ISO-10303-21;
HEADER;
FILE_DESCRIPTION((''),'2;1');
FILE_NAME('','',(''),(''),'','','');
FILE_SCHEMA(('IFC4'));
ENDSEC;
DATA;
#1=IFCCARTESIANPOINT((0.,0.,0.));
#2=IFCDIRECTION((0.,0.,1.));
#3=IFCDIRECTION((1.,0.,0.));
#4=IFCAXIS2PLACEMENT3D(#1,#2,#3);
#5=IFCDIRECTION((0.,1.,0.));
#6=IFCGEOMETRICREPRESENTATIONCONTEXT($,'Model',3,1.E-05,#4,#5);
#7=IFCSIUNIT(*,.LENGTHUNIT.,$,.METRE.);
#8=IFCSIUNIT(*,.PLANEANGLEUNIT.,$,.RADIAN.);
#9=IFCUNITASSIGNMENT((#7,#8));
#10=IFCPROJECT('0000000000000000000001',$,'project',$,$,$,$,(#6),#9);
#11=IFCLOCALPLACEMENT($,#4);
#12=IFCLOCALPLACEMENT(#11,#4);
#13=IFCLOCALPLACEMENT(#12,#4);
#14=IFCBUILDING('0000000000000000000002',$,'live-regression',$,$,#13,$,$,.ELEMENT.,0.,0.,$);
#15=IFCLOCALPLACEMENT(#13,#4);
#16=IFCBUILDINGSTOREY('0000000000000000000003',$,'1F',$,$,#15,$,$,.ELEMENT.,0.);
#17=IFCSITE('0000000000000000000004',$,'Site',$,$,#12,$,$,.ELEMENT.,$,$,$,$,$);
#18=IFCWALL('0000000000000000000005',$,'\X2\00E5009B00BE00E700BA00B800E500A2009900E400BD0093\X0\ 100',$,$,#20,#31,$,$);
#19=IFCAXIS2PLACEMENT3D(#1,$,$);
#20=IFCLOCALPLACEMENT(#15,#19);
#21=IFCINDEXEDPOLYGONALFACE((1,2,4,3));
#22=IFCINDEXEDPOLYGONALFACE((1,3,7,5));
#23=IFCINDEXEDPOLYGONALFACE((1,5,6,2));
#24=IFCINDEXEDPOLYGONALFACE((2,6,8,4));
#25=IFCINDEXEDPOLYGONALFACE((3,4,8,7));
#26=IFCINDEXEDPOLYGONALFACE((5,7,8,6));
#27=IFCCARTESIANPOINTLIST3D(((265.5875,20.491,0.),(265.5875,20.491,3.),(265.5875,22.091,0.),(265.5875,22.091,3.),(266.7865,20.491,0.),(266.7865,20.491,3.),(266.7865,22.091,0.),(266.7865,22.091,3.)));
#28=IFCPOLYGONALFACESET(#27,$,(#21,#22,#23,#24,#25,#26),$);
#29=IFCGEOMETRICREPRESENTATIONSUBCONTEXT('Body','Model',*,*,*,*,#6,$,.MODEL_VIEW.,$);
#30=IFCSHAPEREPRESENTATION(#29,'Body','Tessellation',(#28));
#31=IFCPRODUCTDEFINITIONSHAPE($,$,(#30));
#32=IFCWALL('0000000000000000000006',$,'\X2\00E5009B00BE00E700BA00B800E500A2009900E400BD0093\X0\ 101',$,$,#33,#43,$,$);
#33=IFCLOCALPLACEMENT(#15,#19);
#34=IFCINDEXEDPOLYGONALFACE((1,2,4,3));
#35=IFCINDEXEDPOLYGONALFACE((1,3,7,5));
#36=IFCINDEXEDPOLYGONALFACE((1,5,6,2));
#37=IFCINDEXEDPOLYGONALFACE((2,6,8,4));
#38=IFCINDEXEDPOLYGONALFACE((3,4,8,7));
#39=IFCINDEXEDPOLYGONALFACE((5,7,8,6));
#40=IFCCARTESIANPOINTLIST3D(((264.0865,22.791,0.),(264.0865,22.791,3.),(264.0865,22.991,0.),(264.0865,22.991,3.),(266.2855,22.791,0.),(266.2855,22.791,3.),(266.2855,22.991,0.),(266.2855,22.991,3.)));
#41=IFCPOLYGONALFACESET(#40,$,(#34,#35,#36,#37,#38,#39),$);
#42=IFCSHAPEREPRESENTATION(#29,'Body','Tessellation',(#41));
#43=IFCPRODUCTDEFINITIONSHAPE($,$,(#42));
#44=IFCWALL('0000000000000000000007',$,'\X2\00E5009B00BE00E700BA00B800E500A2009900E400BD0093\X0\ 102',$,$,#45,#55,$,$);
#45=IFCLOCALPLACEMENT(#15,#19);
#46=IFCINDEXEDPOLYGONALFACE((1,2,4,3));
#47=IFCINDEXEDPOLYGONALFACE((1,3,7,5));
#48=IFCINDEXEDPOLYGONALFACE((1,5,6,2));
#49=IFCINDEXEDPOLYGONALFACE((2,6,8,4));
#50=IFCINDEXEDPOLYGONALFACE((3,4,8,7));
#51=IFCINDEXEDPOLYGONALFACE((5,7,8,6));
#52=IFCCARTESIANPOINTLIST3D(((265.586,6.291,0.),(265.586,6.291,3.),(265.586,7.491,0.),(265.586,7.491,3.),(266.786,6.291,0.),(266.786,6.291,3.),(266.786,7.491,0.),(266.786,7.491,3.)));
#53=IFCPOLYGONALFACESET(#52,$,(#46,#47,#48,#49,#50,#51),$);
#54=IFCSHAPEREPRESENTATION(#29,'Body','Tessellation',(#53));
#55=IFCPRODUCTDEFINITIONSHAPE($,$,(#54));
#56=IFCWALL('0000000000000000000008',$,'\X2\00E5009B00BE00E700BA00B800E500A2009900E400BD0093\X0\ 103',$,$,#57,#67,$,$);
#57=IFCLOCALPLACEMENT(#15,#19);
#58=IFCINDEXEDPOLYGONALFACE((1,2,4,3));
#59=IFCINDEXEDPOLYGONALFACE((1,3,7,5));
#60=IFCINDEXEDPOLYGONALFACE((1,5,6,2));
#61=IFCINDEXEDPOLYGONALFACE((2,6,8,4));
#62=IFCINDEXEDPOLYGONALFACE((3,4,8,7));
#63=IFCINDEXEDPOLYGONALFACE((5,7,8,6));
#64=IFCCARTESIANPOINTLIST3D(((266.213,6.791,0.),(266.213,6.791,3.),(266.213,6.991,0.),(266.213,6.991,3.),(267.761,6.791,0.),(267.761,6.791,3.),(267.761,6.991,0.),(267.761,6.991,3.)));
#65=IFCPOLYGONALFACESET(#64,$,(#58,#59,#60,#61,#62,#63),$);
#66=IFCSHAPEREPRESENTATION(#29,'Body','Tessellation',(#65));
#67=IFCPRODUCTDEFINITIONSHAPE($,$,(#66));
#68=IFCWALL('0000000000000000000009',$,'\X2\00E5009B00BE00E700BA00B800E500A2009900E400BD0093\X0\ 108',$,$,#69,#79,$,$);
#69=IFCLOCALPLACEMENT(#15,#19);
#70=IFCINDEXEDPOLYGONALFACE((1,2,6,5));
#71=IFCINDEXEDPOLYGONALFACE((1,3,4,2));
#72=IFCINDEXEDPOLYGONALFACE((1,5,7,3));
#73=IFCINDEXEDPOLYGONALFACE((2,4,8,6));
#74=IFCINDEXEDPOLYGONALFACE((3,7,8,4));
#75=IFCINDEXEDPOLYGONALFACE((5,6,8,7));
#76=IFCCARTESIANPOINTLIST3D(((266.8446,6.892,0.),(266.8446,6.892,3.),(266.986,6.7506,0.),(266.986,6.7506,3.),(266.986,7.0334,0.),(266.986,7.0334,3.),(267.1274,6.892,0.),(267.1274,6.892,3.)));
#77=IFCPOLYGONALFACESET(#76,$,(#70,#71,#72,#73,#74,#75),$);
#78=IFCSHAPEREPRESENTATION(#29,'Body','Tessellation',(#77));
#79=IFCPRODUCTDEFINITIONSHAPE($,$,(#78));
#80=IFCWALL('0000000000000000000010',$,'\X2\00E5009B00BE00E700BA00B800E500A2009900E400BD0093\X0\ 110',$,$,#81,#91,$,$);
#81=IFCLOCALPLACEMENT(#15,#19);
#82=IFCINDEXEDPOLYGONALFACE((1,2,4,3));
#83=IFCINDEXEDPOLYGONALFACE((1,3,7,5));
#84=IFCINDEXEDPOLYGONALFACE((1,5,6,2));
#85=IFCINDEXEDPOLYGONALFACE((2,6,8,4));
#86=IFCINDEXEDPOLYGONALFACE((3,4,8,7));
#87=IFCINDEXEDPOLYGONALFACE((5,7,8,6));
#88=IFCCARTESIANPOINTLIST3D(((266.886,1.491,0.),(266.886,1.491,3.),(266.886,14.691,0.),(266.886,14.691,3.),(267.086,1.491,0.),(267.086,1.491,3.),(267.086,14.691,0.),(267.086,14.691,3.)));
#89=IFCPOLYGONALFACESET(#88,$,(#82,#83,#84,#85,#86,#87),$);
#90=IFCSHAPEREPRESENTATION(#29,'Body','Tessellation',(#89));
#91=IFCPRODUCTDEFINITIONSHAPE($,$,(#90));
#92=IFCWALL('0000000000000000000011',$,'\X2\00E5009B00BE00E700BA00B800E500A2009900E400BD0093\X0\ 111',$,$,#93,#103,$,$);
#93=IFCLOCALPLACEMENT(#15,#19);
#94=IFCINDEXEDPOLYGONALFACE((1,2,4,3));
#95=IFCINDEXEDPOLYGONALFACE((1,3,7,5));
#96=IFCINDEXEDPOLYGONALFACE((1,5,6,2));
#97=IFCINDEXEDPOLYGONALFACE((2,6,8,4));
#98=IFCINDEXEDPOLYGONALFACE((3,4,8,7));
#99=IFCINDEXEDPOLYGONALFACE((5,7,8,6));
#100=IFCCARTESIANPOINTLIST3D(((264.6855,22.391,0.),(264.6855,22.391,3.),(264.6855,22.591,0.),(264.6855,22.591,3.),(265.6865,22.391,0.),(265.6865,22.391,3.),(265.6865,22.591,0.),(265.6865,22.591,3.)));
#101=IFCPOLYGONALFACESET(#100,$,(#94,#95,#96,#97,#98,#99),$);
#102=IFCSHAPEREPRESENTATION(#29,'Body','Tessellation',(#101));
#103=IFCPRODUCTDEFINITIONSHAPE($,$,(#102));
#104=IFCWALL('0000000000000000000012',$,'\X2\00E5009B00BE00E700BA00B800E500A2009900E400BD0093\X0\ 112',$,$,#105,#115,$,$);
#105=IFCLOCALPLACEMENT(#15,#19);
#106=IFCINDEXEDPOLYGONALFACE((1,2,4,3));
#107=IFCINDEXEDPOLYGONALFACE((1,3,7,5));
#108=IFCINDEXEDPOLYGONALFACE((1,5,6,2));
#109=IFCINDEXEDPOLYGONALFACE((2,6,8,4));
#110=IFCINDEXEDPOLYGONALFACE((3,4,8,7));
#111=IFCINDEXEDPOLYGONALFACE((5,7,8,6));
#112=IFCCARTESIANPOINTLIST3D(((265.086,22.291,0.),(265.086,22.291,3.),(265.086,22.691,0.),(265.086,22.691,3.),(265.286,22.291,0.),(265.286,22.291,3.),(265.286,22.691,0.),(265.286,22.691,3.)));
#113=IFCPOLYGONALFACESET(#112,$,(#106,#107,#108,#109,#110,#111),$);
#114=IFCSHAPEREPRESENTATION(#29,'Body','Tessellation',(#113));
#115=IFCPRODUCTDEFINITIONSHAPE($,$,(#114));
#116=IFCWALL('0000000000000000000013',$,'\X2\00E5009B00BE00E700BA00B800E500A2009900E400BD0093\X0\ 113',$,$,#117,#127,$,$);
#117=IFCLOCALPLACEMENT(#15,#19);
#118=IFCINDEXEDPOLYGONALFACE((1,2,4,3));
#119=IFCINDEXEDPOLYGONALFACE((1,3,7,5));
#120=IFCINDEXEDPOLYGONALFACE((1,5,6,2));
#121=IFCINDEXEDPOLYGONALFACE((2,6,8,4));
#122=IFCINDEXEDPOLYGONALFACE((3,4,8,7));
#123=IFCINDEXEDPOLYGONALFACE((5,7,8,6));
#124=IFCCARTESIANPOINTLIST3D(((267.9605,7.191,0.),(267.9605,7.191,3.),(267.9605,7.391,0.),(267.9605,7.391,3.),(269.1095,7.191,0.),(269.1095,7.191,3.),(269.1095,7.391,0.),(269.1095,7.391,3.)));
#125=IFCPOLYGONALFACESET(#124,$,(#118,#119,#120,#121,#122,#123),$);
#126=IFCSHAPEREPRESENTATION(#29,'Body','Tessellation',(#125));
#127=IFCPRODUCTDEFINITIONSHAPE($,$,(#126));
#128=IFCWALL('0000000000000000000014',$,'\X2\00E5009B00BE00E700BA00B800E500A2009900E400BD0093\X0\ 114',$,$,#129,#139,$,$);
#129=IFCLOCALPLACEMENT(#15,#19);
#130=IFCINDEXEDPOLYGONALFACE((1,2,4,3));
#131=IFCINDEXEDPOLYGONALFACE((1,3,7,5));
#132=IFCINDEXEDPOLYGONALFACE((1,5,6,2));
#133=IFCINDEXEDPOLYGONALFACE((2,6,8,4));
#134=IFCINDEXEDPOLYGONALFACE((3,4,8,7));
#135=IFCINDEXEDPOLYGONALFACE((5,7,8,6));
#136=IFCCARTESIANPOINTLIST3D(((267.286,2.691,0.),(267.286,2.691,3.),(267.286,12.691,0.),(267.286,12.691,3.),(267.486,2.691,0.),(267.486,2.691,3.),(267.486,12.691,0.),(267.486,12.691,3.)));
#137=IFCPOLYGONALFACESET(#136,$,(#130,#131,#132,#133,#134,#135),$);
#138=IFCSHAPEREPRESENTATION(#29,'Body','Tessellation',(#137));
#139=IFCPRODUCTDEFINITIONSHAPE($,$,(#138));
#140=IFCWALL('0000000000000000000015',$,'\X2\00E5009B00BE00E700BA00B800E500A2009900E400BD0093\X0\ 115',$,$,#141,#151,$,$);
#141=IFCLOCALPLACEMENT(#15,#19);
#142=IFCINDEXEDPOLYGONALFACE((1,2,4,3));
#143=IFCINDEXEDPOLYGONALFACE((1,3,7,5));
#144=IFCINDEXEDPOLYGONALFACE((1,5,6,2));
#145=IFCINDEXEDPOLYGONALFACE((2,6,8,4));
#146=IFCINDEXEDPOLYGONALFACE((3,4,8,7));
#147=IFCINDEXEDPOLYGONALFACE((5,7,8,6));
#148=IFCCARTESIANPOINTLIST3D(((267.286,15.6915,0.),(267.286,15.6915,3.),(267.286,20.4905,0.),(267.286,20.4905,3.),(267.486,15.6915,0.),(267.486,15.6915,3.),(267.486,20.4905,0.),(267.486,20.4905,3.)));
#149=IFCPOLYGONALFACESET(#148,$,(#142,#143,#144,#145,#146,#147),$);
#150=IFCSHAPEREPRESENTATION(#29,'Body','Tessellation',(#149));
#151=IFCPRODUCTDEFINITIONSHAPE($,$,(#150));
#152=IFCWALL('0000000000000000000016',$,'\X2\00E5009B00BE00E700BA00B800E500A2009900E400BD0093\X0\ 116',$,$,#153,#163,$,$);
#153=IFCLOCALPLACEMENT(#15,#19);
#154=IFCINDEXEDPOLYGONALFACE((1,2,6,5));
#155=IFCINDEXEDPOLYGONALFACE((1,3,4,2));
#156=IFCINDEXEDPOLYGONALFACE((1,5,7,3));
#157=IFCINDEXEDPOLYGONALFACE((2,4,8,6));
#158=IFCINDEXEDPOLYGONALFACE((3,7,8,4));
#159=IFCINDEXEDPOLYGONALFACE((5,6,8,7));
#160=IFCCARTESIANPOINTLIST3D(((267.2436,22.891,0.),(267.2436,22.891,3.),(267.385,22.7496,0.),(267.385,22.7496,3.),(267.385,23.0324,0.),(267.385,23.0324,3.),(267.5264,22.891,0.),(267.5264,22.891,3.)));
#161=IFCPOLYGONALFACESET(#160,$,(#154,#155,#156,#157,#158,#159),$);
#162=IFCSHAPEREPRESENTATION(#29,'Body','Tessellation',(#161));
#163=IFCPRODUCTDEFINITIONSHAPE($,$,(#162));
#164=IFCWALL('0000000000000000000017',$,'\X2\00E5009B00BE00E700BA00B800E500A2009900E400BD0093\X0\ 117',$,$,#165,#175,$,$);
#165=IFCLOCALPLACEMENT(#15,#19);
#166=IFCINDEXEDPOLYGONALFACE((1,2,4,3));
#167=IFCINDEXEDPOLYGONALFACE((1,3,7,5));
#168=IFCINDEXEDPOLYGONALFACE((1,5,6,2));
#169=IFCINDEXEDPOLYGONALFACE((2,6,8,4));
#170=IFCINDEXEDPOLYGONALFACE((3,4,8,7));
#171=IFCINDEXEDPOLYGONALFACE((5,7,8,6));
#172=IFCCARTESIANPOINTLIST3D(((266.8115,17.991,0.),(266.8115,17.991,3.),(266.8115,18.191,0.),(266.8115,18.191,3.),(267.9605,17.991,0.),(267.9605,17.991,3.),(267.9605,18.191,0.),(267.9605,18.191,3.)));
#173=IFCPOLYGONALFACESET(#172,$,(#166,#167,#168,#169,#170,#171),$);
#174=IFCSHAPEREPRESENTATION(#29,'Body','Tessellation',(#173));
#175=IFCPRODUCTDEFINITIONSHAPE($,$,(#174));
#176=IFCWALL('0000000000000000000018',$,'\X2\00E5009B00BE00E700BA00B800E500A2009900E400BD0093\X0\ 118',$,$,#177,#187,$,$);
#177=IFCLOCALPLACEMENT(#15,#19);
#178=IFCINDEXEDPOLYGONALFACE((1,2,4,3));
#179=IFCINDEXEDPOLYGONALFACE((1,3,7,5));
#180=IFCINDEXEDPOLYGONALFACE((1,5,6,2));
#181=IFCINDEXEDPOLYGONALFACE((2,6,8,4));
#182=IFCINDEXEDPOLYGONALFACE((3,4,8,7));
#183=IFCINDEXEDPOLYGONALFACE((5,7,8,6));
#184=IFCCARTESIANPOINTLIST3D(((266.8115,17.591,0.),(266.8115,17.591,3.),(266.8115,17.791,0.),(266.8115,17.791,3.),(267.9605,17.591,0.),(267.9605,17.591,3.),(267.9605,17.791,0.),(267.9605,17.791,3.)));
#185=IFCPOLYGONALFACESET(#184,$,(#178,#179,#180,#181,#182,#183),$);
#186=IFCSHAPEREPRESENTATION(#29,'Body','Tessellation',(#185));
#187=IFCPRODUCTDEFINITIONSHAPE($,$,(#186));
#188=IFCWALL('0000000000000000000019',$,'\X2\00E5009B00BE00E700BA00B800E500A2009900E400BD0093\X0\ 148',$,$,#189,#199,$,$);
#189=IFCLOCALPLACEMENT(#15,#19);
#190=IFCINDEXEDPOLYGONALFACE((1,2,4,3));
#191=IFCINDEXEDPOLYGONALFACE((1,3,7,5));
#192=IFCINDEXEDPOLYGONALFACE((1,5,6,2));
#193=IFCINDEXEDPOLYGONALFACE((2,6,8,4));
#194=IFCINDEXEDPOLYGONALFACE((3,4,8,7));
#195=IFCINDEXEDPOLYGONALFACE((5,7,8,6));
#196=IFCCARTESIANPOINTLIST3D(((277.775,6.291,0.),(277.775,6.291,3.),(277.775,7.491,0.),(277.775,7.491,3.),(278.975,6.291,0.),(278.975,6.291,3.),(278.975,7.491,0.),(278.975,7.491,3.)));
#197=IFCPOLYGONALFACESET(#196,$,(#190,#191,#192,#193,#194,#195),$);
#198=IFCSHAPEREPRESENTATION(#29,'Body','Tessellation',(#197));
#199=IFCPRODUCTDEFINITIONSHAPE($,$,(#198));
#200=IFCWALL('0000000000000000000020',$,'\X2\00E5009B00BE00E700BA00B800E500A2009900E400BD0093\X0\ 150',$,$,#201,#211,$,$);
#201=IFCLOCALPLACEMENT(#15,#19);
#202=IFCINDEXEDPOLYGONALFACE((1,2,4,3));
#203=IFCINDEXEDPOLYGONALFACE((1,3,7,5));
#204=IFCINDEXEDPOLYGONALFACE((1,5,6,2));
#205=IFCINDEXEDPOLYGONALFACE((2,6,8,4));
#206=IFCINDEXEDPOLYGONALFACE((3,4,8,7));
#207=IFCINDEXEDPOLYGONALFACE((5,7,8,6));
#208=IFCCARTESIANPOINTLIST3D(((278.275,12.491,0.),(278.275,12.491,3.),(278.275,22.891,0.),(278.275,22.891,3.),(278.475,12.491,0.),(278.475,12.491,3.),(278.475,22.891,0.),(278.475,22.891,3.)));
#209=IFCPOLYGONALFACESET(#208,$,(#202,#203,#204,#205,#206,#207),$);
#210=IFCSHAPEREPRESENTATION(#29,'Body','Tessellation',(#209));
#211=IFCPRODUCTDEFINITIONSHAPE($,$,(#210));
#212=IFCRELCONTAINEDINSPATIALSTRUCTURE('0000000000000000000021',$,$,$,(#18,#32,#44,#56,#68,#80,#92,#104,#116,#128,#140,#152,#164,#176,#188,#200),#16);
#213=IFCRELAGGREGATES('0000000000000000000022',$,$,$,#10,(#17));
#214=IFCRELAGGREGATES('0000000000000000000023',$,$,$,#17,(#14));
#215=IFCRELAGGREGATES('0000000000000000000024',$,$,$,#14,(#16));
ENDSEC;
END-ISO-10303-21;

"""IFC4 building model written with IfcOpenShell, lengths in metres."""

from ifc_helpers import new_model, si_unit, direction, frame, frame_2d, origin_with_axes, place, context, subcontext, project, spatial, rectangle, extrude, element, save


model = new_model("IFC4")

# Units and contexts
model_context = context("Model", 3, precision=1e-05, world=origin_with_axes(), true_north=direction((0.0, 1.0, 0.0)))
body_context = subcontext(model_context, "Body", "Model", "MODEL_VIEW")
ifc_project = project(units=[si_unit("LENGTHUNIT", "METRE"), si_unit("PLANEANGLEUNIT", "RADIAN")], contexts=[model_context])

# Site, building, storey
placement = place(None, origin_with_axes())
site_placement = place(placement, origin_with_axes())
site = spatial("IfcSite", under=ifc_project, at=site_placement, Name="Site", CompositionType="ELEMENT")
building_placement = place(site_placement, origin_with_axes())
building = spatial("IfcBuilding", under=site, at=building_placement, Name="live-regression", CompositionType="ELEMENT", ElevationOfRefHeight=0.0, ElevationOfTerrain=0.0)
storey_placement = place(building_placement, origin_with_axes())
storey = spatial("IfcBuildingStorey", under=building, at=storey_placement, Name="1F", CompositionType="ELEMENT", Elevation=0.0)

# Walls
wall_1_placement = place(storey_placement, frame((266.187, 21.291, 0.0), z_axis=(0.0, 0.0, 1.0), x_axis=(1.0, 0.0, 0.0)))
element("IfcWall", 1, at=wall_1_placement, inside=storey, Name="å\u009b¾çº¸å¢\u0099ä½\u0093 100", context=body_context, shape_type="SweptSolid", body=[
    extrude(rectangle(XDim=1.199, YDim=1.6, at=frame_2d((0.0, 0.0), x_axis=(1.0, 0.0, 0.0))), frame((0.0, 0.0, 0.0), z_axis=(0.0, 0.0, 1.0)), (0.0, 0.0, 1.0), 3.0),
])
wall_2_placement = place(storey_placement, frame((265.186, 22.891, 0.0), z_axis=(0.0, 0.0, 1.0), x_axis=(1.0, 0.0, 0.0)))
element("IfcWall", 2, at=wall_2_placement, inside=storey, Name="å\u009b¾çº¸å¢\u0099ä½\u0093 101", context=body_context, shape_type="SweptSolid", body=[
    extrude(rectangle(XDim=2.199, YDim=0.2, at=frame_2d((0.0, 0.0), x_axis=(1.0, 0.0, 0.0))), frame((0.0, 0.0, 0.0), z_axis=(0.0, 0.0, 1.0)), (0.0, 0.0, 1.0), 3.0),
])
wall_3_placement = place(storey_placement, frame((266.186, 6.891, 0.0), z_axis=(0.0, 0.0, 1.0), x_axis=(1.0, 0.0, 0.0)))
element("IfcWall", 3, at=wall_3_placement, inside=storey, Name="å\u009b¾çº¸å¢\u0099ä½\u0093 102", context=body_context, shape_type="SweptSolid", body=[
    extrude(rectangle(XDim=1.2, YDim=1.2, at=frame_2d((0.0, 0.0), x_axis=(1.0, 0.0, 0.0))), frame((0.0, 0.0, 0.0), z_axis=(0.0, 0.0, 1.0)), (0.0, 0.0, 1.0), 3.0),
])
wall_4_placement = place(storey_placement, frame((266.987, 6.891, 0.0), z_axis=(0.0, 0.0, 1.0), x_axis=(1.0, 0.0, 0.0)))
element("IfcWall", 4, at=wall_4_placement, inside=storey, Name="å\u009b¾çº¸å¢\u0099ä½\u0093 103", context=body_context, shape_type="SweptSolid", body=[
    extrude(rectangle(XDim=1.548, YDim=0.2, at=frame_2d((0.0, 0.0), x_axis=(1.0, 0.0, 0.0))), frame((0.0, 0.0, 0.0), z_axis=(0.0, 0.0, 1.0)), (0.0, 0.0, 1.0), 3.0),
])
wall_5_placement = place(storey_placement, frame((266.986, 6.892, 0.0), z_axis=(0.0, 0.0, 1.0), x_axis=(0.707107, -0.707107, 0.0)))
element("IfcWall", 5, at=wall_5_placement, inside=storey, Name="å\u009b¾çº¸å¢\u0099ä½\u0093 108", context=body_context, shape_type="SweptSolid", body=[
    extrude(rectangle(XDim=0.2, YDim=0.2, at=frame_2d((0.0, 0.0), x_axis=(1.0, 0.0, 0.0))), frame((0.0, 0.0, 0.0), z_axis=(0.0, 0.0, 1.0)), (0.0, 0.0, 1.0), 3.0),
])
wall_6_placement = place(storey_placement, frame((266.986, 8.091, 0.0), z_axis=(0.0, 0.0, 1.0), x_axis=(0.0, 1.0, 0.0)))
element("IfcWall", 6, at=wall_6_placement, inside=storey, Name="å\u009b¾çº¸å¢\u0099ä½\u0093 110", context=body_context, shape_type="SweptSolid", body=[
    extrude(rectangle(XDim=13.2, YDim=0.2, at=frame_2d((0.0, 0.0), x_axis=(1.0, 0.0, 0.0))), frame((0.0, 0.0, 0.0), z_axis=(0.0, 0.0, 1.0)), (0.0, 0.0, 1.0), 3.0),
])
wall_7_placement = place(storey_placement, frame((265.186, 22.491, 0.0), z_axis=(0.0, 0.0, 1.0), x_axis=(1.0, 0.0, 0.0)))
element("IfcWall", 7, at=wall_7_placement, inside=storey, Name="å\u009b¾çº¸å¢\u0099ä½\u0093 111", context=body_context, shape_type="SweptSolid", body=[
    extrude(rectangle(XDim=1.001, YDim=0.2, at=frame_2d((0.0, 0.0), x_axis=(1.0, 0.0, 0.0))), frame((0.0, 0.0, 0.0), z_axis=(0.0, 0.0, 1.0)), (0.0, 0.0, 1.0), 3.0),
])
wall_8_placement = place(storey_placement, frame((265.186, 22.491, 0.0), z_axis=(0.0, 0.0, 1.0), x_axis=(0.0, 1.0, 0.0)))
element("IfcWall", 8, at=wall_8_placement, inside=storey, Name="å\u009b¾çº¸å¢\u0099ä½\u0093 112", context=body_context, shape_type="SweptSolid", body=[
    extrude(rectangle(XDim=0.4, YDim=0.2, at=frame_2d((0.0, 0.0), x_axis=(1.0, 0.0, 0.0))), frame((0.0, 0.0, 0.0), z_axis=(0.0, 0.0, 1.0)), (0.0, 0.0, 1.0), 3.0),
])
wall_9_placement = place(storey_placement, frame((268.535, 7.291, 0.0), z_axis=(0.0, 0.0, 1.0), x_axis=(-1.0, 0.0, 0.0)))
element("IfcWall", 9, at=wall_9_placement, inside=storey, Name="å\u009b¾çº¸å¢\u0099ä½\u0093 113", context=body_context, shape_type="SweptSolid", body=[
    extrude(rectangle(XDim=1.149, YDim=0.2, at=frame_2d((0.0, 0.0), x_axis=(1.0, 0.0, 0.0))), frame((0.0, 0.0, 0.0), z_axis=(0.0, 0.0, 1.0)), (0.0, 0.0, 1.0), 3.0),
])
wall_10_placement = place(storey_placement, frame((267.386, 7.691, 0.0), z_axis=(0.0, 0.0, 1.0), x_axis=(0.0, 1.0, 0.0)))
element("IfcWall", 10, at=wall_10_placement, inside=storey, Name="å\u009b¾çº¸å¢\u0099ä½\u0093 114", context=body_context, shape_type="SweptSolid", body=[
    extrude(rectangle(XDim=10.0, YDim=0.2, at=frame_2d((0.0, 0.0), x_axis=(1.0, 0.0, 0.0))), frame((0.0, 0.0, 0.0), z_axis=(0.0, 0.0, 1.0)), (0.0, 0.0, 1.0), 3.0),
])
wall_11_placement = place(storey_placement, frame((267.386, 18.091, 0.0), z_axis=(0.0, 0.0, 1.0), x_axis=(0.0, 1.0, 0.0)))
element("IfcWall", 11, at=wall_11_placement, inside=storey, Name="å\u009b¾çº¸å¢\u0099ä½\u0093 115", context=body_context, shape_type="SweptSolid", body=[
    extrude(rectangle(XDim=4.799, YDim=0.2, at=frame_2d((0.0, 0.0), x_axis=(1.0, 0.0, 0.0))), frame((0.0, 0.0, 0.0), z_axis=(0.0, 0.0, 1.0)), (0.0, 0.0, 1.0), 3.0),
])
wall_12_placement = place(storey_placement, frame((267.385, 22.891, 0.0), z_axis=(0.0, 0.0, 1.0), x_axis=(0.707107, -0.707107, 0.0)))
element("IfcWall", 12, at=wall_12_placement, inside=storey, Name="å\u009b¾çº¸å¢\u0099ä½\u0093 116", context=body_context, shape_type="SweptSolid", body=[
    extrude(rectangle(XDim=0.2, YDim=0.2, at=frame_2d((0.0, 0.0), x_axis=(1.0, 0.0, 0.0))), frame((0.0, 0.0, 0.0), z_axis=(0.0, 0.0, 1.0)), (0.0, 0.0, 1.0), 3.0),
])
for number, where, z_axis, x_axis, name in (
    (13, (267.386, 18.091, 0.0), (0.0, 0.0, 1.0), (1.0, 0.0, 0.0), "å\u009b¾çº¸å¢\u0099ä½\u0093 117"),
    (14, (267.386, 17.691, 0.0), (0.0, 0.0, 1.0), (1.0, 0.0, 0.0), "å\u009b¾çº¸å¢\u0099ä½\u0093 118"),
):
    element("IfcWall", number, at=place(storey_placement, frame(where, z_axis=z_axis, x_axis=x_axis)), inside=storey, Name=name, context=body_context, shape_type="SweptSolid", body=[
        extrude(rectangle(XDim=1.149, YDim=0.2, at=frame_2d((0.0, 0.0), x_axis=(1.0, 0.0, 0.0))), frame((0.0, 0.0, 0.0), z_axis=(0.0, 0.0, 1.0)), (0.0, 0.0, 1.0), 3.0),
    ])
wall_13_placement = place(storey_placement, frame((278.375, 6.891, 0.0), z_axis=(0.0, 0.0, 1.0), x_axis=(1.0, 0.0, 0.0)))
element("IfcWall", 15, at=wall_13_placement, inside=storey, Name="å\u009b¾çº¸å¢\u0099ä½\u0093 148", context=body_context, shape_type="SweptSolid", body=[
    extrude(rectangle(XDim=1.2, YDim=1.2, at=frame_2d((0.0, 0.0), x_axis=(1.0, 0.0, 0.0))), frame((0.0, 0.0, 0.0), z_axis=(0.0, 0.0, 1.0)), (0.0, 0.0, 1.0), 3.0),
])
wall_14_placement = place(storey_placement, frame((278.375, 17.691, 0.0), z_axis=(0.0, 0.0, 1.0), x_axis=(0.0, -1.0, 0.0)))
element("IfcWall", 16, at=wall_14_placement, inside=storey, Name="å\u009b¾çº¸å¢\u0099ä½\u0093 150", context=body_context, shape_type="SweptSolid", body=[
    extrude(rectangle(XDim=10.4, YDim=0.2, at=frame_2d((0.0, 0.0), x_axis=(1.0, 0.0, 0.0))), frame((0.0, 0.0, 0.0), z_axis=(0.0, 0.0, 1.0)), (0.0, 0.0, 1.0), 3.0),
])

save(model, "model.ifc")
